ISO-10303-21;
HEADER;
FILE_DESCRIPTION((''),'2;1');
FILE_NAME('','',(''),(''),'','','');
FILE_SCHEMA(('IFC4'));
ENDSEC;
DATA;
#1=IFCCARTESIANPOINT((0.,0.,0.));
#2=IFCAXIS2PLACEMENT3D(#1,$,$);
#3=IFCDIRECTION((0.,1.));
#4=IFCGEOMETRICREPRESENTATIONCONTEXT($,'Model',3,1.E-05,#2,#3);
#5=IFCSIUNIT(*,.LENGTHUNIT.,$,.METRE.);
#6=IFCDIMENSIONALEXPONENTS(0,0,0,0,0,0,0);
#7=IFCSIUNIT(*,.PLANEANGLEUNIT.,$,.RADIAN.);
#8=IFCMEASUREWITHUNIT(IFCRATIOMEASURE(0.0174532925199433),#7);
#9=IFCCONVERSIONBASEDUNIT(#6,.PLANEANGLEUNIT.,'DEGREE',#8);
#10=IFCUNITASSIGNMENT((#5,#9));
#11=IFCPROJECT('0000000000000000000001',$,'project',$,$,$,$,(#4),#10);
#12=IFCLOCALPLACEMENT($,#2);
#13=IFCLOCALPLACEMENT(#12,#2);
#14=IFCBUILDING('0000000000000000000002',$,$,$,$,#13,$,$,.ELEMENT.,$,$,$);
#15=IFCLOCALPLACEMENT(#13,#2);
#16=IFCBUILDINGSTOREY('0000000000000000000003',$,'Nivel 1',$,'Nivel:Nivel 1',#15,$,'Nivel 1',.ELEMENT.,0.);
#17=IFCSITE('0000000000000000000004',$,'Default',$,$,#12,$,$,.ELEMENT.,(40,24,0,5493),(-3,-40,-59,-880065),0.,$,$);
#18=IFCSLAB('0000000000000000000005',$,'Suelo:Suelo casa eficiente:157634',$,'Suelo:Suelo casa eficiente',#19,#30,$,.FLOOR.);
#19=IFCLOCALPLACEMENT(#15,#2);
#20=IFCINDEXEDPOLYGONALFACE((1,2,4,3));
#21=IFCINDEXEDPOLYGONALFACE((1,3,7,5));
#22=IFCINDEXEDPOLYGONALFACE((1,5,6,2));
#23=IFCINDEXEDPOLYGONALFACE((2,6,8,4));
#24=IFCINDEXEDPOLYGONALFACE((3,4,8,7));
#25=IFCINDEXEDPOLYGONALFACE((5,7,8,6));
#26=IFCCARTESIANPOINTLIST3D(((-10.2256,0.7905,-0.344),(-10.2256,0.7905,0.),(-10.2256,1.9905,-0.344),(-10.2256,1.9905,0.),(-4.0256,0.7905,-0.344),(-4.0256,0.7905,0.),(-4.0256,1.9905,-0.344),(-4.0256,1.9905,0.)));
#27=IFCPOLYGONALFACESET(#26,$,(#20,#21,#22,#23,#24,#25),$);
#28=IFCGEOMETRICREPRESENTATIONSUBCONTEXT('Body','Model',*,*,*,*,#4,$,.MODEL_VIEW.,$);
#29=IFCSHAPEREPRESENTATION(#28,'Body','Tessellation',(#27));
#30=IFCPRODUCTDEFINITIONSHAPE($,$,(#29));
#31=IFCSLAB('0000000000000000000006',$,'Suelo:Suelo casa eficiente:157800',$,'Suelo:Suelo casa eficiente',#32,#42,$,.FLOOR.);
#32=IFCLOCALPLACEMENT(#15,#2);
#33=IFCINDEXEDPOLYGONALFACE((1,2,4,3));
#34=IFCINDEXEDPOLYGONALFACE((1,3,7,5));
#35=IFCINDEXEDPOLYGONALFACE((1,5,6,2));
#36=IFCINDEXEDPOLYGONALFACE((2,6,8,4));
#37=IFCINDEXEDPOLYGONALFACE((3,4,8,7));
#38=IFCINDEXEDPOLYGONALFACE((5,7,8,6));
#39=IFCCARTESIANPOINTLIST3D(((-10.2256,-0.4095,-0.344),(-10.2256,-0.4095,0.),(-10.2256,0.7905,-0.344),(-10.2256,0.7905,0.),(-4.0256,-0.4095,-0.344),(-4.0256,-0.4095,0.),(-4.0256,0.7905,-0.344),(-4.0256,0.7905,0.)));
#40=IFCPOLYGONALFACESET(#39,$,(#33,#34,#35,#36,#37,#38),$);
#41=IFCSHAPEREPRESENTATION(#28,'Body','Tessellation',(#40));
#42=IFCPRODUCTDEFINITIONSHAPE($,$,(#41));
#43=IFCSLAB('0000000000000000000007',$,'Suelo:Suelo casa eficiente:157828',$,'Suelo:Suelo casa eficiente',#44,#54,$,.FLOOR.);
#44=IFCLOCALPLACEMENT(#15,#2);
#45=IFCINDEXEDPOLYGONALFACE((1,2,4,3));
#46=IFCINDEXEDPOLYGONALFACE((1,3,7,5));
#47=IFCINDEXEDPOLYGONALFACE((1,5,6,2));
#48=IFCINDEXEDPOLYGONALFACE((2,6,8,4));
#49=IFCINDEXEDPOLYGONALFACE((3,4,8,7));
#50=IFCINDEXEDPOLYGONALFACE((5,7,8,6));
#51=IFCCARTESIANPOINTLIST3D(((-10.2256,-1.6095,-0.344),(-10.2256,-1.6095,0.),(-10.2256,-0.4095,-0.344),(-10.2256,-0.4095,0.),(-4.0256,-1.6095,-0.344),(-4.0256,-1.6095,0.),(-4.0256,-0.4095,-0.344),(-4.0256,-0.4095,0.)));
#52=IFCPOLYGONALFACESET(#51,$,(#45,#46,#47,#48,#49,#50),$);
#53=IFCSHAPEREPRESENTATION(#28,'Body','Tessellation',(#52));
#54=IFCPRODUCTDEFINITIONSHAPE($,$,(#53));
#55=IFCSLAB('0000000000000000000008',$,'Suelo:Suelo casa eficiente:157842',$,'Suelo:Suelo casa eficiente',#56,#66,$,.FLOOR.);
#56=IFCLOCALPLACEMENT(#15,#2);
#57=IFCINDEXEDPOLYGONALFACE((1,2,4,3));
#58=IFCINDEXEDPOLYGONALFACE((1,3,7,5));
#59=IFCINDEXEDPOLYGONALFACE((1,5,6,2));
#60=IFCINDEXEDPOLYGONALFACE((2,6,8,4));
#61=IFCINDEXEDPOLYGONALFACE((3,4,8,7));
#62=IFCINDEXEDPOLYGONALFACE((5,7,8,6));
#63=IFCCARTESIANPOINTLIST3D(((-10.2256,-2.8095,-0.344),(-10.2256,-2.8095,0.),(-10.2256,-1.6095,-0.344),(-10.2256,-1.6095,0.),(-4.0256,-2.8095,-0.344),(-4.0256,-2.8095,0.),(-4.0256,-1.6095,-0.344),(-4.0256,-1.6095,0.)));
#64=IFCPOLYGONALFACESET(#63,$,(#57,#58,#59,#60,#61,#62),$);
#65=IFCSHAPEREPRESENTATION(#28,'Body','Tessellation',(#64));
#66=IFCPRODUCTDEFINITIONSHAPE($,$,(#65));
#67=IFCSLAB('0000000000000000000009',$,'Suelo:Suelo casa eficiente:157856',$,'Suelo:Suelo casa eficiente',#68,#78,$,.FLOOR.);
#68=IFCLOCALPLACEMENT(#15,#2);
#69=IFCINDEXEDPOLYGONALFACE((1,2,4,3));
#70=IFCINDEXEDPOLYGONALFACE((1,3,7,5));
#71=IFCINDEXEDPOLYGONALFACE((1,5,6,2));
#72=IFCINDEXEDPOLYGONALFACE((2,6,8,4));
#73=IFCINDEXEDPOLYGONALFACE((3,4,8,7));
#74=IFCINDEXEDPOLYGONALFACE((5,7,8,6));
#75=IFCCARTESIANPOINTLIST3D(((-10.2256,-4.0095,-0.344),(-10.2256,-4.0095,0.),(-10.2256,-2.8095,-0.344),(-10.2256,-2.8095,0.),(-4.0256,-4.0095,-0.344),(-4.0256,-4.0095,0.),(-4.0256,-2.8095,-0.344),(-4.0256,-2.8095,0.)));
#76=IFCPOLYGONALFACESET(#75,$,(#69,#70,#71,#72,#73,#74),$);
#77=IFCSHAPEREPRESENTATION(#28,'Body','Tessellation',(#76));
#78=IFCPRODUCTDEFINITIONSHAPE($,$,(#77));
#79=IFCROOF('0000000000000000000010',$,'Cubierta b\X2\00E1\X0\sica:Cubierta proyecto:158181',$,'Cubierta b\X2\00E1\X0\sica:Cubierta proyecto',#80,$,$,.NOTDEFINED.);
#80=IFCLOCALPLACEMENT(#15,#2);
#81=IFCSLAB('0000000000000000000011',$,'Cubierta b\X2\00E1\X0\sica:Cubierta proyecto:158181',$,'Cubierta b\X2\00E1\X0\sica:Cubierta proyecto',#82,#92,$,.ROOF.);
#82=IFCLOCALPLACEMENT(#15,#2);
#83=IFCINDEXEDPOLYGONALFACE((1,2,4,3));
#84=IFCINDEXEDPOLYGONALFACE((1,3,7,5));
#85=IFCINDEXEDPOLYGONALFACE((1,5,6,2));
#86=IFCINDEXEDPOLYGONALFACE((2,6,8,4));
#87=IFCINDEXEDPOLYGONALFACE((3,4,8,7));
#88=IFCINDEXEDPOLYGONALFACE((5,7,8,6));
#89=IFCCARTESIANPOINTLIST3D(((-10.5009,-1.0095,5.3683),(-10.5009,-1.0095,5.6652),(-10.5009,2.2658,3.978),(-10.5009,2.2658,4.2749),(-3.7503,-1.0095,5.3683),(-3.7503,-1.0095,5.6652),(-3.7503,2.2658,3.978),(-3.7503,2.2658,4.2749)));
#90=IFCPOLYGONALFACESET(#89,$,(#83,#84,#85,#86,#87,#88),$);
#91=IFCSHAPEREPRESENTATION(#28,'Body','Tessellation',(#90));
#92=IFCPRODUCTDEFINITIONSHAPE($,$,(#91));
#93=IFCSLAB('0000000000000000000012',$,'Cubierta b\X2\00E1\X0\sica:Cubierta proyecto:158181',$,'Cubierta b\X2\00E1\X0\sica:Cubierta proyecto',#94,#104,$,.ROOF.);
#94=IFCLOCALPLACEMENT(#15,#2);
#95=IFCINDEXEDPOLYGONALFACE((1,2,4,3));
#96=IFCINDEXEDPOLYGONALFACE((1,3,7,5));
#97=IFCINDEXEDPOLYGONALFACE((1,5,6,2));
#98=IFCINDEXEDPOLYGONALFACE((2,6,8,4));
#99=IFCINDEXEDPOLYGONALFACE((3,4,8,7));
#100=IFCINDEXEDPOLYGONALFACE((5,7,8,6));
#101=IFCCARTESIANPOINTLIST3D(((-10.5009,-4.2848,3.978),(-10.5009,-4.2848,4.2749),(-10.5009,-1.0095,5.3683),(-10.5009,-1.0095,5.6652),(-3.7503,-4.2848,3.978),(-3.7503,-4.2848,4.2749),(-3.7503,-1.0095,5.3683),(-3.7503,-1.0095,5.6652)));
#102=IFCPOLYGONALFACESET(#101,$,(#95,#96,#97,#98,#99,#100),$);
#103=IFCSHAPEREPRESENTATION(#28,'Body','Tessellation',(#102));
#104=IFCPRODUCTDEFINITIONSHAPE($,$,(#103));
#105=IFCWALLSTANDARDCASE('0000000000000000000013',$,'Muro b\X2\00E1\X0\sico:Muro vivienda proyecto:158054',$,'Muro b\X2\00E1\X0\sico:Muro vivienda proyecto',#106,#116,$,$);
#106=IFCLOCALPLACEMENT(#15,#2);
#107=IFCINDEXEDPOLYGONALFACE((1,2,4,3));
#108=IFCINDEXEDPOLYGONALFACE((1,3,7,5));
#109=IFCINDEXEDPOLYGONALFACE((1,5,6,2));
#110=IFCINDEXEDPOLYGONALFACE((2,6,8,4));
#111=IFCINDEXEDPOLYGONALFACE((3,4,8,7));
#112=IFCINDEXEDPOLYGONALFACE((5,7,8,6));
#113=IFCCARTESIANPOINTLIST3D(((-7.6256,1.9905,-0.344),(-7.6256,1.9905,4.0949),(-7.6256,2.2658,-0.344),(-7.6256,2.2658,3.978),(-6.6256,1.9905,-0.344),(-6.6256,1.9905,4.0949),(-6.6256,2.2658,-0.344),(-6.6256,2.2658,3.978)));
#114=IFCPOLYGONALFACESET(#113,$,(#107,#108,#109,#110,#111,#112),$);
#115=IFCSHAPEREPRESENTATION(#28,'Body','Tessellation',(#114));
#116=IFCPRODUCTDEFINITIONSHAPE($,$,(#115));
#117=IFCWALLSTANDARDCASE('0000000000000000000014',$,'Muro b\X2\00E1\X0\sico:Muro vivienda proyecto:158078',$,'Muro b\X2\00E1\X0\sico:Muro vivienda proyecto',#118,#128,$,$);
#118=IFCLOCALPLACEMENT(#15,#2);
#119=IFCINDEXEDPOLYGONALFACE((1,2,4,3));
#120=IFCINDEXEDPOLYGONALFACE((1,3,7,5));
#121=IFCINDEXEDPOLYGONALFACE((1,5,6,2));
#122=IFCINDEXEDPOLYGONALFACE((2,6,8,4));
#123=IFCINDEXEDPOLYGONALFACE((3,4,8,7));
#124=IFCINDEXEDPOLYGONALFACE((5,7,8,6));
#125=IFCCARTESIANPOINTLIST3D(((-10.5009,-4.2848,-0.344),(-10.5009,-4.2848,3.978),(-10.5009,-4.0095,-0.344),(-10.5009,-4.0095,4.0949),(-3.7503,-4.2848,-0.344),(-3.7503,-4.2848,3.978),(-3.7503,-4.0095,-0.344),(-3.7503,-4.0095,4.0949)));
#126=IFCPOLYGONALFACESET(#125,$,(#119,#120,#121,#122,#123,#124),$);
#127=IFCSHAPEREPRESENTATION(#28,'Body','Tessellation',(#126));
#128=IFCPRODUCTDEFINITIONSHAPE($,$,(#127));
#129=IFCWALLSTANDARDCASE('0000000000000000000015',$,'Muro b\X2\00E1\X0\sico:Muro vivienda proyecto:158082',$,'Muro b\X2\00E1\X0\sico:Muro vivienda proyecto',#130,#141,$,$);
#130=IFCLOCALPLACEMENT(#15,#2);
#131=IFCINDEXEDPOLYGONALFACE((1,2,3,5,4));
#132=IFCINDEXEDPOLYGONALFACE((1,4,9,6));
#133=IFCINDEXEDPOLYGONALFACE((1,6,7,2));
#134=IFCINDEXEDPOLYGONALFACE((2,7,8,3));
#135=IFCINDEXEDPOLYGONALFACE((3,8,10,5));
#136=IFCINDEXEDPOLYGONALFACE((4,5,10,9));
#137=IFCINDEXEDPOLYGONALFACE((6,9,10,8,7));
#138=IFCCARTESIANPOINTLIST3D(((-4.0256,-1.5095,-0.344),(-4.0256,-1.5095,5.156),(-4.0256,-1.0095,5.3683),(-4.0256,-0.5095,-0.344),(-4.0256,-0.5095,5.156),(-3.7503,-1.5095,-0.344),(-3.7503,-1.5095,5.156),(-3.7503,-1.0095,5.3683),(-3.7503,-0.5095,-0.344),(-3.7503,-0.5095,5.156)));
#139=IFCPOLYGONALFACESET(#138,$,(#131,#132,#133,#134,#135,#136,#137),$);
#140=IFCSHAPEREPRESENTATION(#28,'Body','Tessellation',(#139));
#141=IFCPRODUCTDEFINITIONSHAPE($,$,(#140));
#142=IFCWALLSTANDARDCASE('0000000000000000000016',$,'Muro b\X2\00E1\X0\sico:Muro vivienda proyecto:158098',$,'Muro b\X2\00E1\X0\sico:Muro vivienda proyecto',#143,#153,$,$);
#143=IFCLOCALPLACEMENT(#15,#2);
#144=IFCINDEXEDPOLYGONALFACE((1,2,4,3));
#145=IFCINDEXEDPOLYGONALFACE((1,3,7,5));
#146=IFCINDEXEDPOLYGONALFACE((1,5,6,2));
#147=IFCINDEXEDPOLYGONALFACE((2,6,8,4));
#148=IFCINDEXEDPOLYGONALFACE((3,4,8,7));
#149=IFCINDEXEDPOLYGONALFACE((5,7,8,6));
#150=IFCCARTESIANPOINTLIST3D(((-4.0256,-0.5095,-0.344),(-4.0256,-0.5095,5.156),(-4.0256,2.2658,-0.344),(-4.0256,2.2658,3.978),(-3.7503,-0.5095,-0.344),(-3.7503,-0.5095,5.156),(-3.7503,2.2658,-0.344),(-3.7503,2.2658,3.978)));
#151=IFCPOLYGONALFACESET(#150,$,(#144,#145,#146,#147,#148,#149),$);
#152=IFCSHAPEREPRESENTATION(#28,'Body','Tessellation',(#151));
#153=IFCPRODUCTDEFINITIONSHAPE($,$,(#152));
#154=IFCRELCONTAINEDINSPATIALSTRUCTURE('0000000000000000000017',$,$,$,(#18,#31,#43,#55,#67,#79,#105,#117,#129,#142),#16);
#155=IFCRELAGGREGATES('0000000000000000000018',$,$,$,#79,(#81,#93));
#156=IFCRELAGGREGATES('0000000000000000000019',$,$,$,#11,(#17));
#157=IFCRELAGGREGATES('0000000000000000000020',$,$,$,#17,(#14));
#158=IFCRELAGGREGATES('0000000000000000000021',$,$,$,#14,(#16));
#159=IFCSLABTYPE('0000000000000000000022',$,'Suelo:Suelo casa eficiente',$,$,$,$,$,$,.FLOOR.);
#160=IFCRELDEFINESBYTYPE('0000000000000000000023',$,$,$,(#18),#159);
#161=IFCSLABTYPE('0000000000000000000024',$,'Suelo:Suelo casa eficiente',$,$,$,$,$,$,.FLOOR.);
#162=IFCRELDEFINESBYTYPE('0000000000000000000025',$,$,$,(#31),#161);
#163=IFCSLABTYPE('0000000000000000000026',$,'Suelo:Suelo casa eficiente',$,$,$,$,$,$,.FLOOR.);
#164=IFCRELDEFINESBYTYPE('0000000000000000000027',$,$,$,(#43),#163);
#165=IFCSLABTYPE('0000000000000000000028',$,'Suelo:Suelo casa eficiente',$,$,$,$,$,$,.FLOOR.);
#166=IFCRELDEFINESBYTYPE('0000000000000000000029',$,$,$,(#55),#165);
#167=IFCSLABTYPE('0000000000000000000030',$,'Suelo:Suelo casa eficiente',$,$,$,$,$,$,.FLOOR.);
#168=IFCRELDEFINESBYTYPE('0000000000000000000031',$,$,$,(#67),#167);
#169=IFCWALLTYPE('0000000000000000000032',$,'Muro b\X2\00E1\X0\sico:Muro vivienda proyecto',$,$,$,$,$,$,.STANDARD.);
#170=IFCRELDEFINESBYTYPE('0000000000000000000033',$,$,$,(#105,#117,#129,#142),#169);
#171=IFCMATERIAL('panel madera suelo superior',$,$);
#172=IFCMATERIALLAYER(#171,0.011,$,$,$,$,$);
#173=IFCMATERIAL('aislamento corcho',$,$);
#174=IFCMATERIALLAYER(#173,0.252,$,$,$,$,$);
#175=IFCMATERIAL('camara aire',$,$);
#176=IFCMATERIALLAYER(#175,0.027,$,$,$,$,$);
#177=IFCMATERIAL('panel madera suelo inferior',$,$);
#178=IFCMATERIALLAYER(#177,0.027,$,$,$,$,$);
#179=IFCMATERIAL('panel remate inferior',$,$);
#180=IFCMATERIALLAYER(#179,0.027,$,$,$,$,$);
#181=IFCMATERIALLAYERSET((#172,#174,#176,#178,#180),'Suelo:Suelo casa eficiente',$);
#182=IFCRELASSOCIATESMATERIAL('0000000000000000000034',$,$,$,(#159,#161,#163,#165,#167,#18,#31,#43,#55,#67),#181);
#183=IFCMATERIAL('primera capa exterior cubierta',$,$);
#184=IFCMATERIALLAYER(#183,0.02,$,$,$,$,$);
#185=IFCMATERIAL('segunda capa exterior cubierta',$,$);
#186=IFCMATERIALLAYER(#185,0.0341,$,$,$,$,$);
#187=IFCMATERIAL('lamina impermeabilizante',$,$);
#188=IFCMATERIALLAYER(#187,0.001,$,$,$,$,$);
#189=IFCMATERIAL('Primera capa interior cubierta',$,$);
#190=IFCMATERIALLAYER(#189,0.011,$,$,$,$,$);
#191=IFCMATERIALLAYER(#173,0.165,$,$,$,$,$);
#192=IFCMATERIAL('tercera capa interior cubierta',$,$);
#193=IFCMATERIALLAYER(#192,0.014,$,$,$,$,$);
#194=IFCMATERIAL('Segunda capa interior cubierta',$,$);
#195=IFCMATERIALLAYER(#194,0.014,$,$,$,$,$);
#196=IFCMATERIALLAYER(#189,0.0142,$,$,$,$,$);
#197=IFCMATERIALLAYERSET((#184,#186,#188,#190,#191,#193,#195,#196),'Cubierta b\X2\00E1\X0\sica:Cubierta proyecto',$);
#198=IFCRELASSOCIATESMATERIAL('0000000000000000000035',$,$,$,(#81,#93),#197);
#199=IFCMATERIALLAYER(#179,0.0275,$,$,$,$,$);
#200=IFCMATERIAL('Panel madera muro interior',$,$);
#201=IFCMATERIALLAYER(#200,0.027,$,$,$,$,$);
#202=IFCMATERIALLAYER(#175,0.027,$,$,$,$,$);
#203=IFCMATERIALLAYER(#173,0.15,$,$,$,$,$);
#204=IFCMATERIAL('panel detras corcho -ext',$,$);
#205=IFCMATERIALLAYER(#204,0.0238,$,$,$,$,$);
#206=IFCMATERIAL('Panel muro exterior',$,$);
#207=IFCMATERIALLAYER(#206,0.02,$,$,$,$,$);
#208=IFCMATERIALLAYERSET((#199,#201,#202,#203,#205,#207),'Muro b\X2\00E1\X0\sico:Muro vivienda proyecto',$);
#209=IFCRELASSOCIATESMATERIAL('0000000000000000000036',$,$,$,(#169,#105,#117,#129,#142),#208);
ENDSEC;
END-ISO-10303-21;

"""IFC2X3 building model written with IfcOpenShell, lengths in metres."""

from ifc_helpers import new_model, entity, si_unit, converted_unit, direction, frame, frame_2d, origin, place, context, subcontext, project, spatial, polyline, rectangle, extrude, clip, bounded_halfspace, material, layer, layer_set, layer_usage, type_object, element, aggregate, save


model = new_model("IFC2X3")

# Units and contexts
model_context = context("Model", 3, precision=1e-05, world=origin(), true_north=direction((0.0, 1.0)))
body_context = subcontext(model_context, "Body", "Model", "MODEL_VIEW")
ifc_project = project(units=[si_unit("LENGTHUNIT", "METRE"), converted_unit("PLANEANGLEUNIT", "DEGREE", entity("IfcRatioMeasure", 0.0174532925199433), si_unit("PLANEANGLEUNIT", "RADIAN"), dimensions=[0, 0, 0, 0, 0, 0, 0])], contexts=[model_context])

# Site, building, storey
site_placement = place(None, origin())
site = spatial("IfcSite", under=ifc_project, at=site_placement, Name="Default", CompositionType="ELEMENT", RefLatitude=(40, 24, 0, 5493), RefLongitude=(-3, -40, -59, -880065), RefElevation=0.0)
building_placement = place(site_placement, origin())
building = spatial("IfcBuilding", under=site, at=building_placement, CompositionType="ELEMENT")
storey_placement = place(building_placement, origin())
storey = spatial("IfcBuildingStorey", under=building, at=storey_placement, Name="Nivel 1", ObjectType="Nivel:Nivel 1", LongName="Nivel 1", CompositionType="ELEMENT", Elevation=0.0)

# Slabs
ifc_material_1 = material(Name="panel madera suelo superior")
ifc_layer_1 = layer(ifc_material_1, 0.011)
ifc_material_2 = material(Name="aislamento corcho")
ifc_layer_2 = layer(ifc_material_2, 0.252)
ifc_material_3 = material(Name="camara aire")
ifc_layer_3 = layer(ifc_material_3, 0.027)
ifc_material_4 = material(Name="panel madera suelo inferior")
ifc_layer_4 = layer(ifc_material_4, 0.027)
ifc_material_5 = material(Name="panel remate inferior")
ifc_layer_5 = layer(ifc_material_5, 0.027)
ifc_layer_set_1 = layer_set([ifc_layer_1, ifc_layer_2, ifc_layer_3, ifc_layer_4, ifc_layer_5], Name="Suelo:Suelo casa eficiente")
ifc_layer_usage_1 = layer_usage(ifc_layer_set_1, "AXIS3", "POSITIVE", 0.0)
slab_type_1 = type_object("IfcSlabType", Name="Suelo:Suelo casa eficiente", PredefinedType="FLOOR", material=ifc_layer_set_1)
slab_1_placement = place(storey_placement, origin())
element("IfcSlab", 1, at=slab_1_placement, inside=storey, type_object=slab_type_1, material=ifc_layer_usage_1, Name="Suelo:Suelo casa eficiente:157634", ObjectType="Suelo:Suelo casa eficiente", PredefinedType="FLOOR", context=body_context, shape_type="SweptSolid", body=[
    extrude(rectangle(XDim=1.2, YDim=6.2, at=frame_2d((0.0, 0.0), x_axis=(1.0, 0.0))), frame((-7.1256, 1.3905, 0.0), z_axis=(0.0, 0.0, -1.0), x_axis=(0.0, 1.0, 0.0)), (0.0, 0.0, 1.0), 0.344),
])
ifc_layer_usage_2 = layer_usage(ifc_layer_set_1, "AXIS3", "POSITIVE", 0.0)
slab_type_2 = type_object("IfcSlabType", Name="Suelo:Suelo casa eficiente", PredefinedType="FLOOR", material=ifc_layer_set_1)
slab_2_placement = place(storey_placement, origin())
element("IfcSlab", 2, at=slab_2_placement, inside=storey, type_object=slab_type_2, material=ifc_layer_usage_2, Name="Suelo:Suelo casa eficiente:157800", ObjectType="Suelo:Suelo casa eficiente", PredefinedType="FLOOR", context=body_context, shape_type="SweptSolid", body=[
    extrude(rectangle(XDim=1.2, YDim=6.2, at=frame_2d((0.0, 0.0), x_axis=(1.0, 0.0))), frame((-7.1256, 0.1905, 0.0), z_axis=(0.0, 0.0, -1.0), x_axis=(0.0, 1.0, 0.0)), (0.0, 0.0, 1.0), 0.344),
])
ifc_layer_usage_3 = layer_usage(ifc_layer_set_1, "AXIS3", "POSITIVE", 0.0)
slab_type_3 = type_object("IfcSlabType", Name="Suelo:Suelo casa eficiente", PredefinedType="FLOOR", material=ifc_layer_set_1)
slab_3_placement = place(storey_placement, origin())
element("IfcSlab", 3, at=slab_3_placement, inside=storey, type_object=slab_type_3, material=ifc_layer_usage_3, Name="Suelo:Suelo casa eficiente:157828", ObjectType="Suelo:Suelo casa eficiente", PredefinedType="FLOOR", context=body_context, shape_type="SweptSolid", body=[
    extrude(rectangle(XDim=1.2, YDim=6.2, at=frame_2d((0.0, 0.0), x_axis=(1.0, 0.0))), frame((-7.1256, -1.0095, 0.0), z_axis=(0.0, 0.0, -1.0), x_axis=(0.0, 1.0, 0.0)), (0.0, 0.0, 1.0), 0.344),
])
ifc_layer_usage_4 = layer_usage(ifc_layer_set_1, "AXIS3", "POSITIVE", 0.0)
slab_type_4 = type_object("IfcSlabType", Name="Suelo:Suelo casa eficiente", PredefinedType="FLOOR", material=ifc_layer_set_1)
slab_4_placement = place(storey_placement, origin())
element("IfcSlab", 4, at=slab_4_placement, inside=storey, type_object=slab_type_4, material=ifc_layer_usage_4, Name="Suelo:Suelo casa eficiente:157842", ObjectType="Suelo:Suelo casa eficiente", PredefinedType="FLOOR", context=body_context, shape_type="SweptSolid", body=[
    extrude(rectangle(XDim=1.2, YDim=6.2, at=frame_2d((0.0, 0.0), x_axis=(1.0, 0.0))), frame((-7.1256, -2.2095, 0.0), z_axis=(0.0, 0.0, -1.0), x_axis=(0.0, 1.0, 0.0)), (0.0, 0.0, 1.0), 0.344),
])
ifc_layer_usage_5 = layer_usage(ifc_layer_set_1, "AXIS3", "POSITIVE", 0.0)
slab_type_5 = type_object("IfcSlabType", Name="Suelo:Suelo casa eficiente", PredefinedType="FLOOR", material=ifc_layer_set_1)
slab_5_placement = place(storey_placement, origin())
element("IfcSlab", 5, at=slab_5_placement, inside=storey, type_object=slab_type_5, material=ifc_layer_usage_5, Name="Suelo:Suelo casa eficiente:157856", ObjectType="Suelo:Suelo casa eficiente", PredefinedType="FLOOR", context=body_context, shape_type="SweptSolid", body=[
    extrude(rectangle(XDim=1.2, YDim=6.2, at=frame_2d((0.0, 0.0), x_axis=(1.0, 0.0))), frame((-7.1256, -3.4095, 0.0), z_axis=(0.0, 0.0, -1.0), x_axis=(0.0, 1.0, 0.0)), (0.0, 0.0, 1.0), 0.344),
])

# Roof, slabs
roof_placement = place(storey_placement, frame((-10.5009, -4.2848, 3.978)))
roof = element("IfcRoof", 6, at=roof_placement, inside=storey, Name="Cubierta básica:Cubierta proyecto:158181", ObjectType="Cubierta básica:Cubierta proyecto", ShapeType="NOTDEFINED")
ifc_material_6 = material(Name="primera capa exterior cubierta")
ifc_layer_6 = layer(ifc_material_6, 0.02)
ifc_material_7 = material(Name="segunda capa exterior cubierta")
ifc_layer_7 = layer(ifc_material_7, 0.0341)
ifc_material_8 = material(Name="lamina impermeabilizante")
ifc_layer_8 = layer(ifc_material_8, 0.001)
ifc_material_9 = material(Name="Primera capa interior cubierta")
ifc_layer_9 = layer(ifc_material_9, 0.011)
ifc_layer_10 = layer(ifc_material_2, 0.165)
ifc_material_10 = material(Name="tercera capa interior cubierta")
ifc_layer_11 = layer(ifc_material_10, 0.014)
ifc_material_11 = material(Name="Segunda capa interior cubierta")
ifc_layer_12 = layer(ifc_material_11, 0.014)
ifc_layer_13 = layer(ifc_material_9, 0.0142)
ifc_layer_set_2 = layer_set([ifc_layer_6, ifc_layer_7, ifc_layer_8, ifc_layer_9, ifc_layer_10, ifc_layer_11, ifc_layer_12, ifc_layer_13], Name="Cubierta básica:Cubierta proyecto")
slab_6_placement = place(roof_placement, origin())
slab_6 = element("IfcSlab", 7, at=slab_6_placement, material=ifc_layer_set_2, Name="Cubierta básica:Cubierta proyecto:158181", ObjectType="Cubierta básica:Cubierta proyecto", PredefinedType="ROOF", context=body_context, shape_type="SweptSolid", body=[
    extrude(rectangle(XDim=6.7506, YDim=3.5582, at=frame_2d((0.0, 0.0), x_axis=(1.0, 0.0))), frame((3.3753, 4.913, 0.6951), z_axis=(0.0, 0.390731, 0.920505), x_axis=(1.0, 0.0, 0.0)), (0.0, -0.390731, 0.920505), 0.2969),
])
slab_7_placement = place(roof_placement, origin())
slab_7 = element("IfcSlab", 8, at=slab_7_placement, material=ifc_layer_set_2, Name="Cubierta básica:Cubierta proyecto:158181", ObjectType="Cubierta básica:Cubierta proyecto", PredefinedType="ROOF", context=body_context, shape_type="SweptSolid", body=[
    extrude(rectangle(XDim=3.5582, YDim=6.7506, at=frame_2d((0.0, 0.0), x_axis=(0.0, 1.0))), frame((3.3753, 1.6377, 0.6951), z_axis=(0.0, -0.390731, 0.920505), x_axis=(1.0, 0.0, 0.0)), (0.0, 0.390731, 0.920505), 0.2969),
])
aggregate(roof, [slab_6, slab_7])

# Walls
ifc_layer_14 = layer(ifc_material_5, 0.0275)
ifc_material_12 = material(Name="Panel madera muro interior")
ifc_layer_15 = layer(ifc_material_12, 0.027)
ifc_layer_16 = layer(ifc_material_3, 0.027)
ifc_layer_17 = layer(ifc_material_2, 0.15)
ifc_material_13 = material(Name="panel detras corcho -ext")
ifc_layer_18 = layer(ifc_material_13, 0.0238)
ifc_material_14 = material(Name="Panel muro exterior")
ifc_layer_19 = layer(ifc_material_14, 0.02)
ifc_layer_set_3 = layer_set([ifc_layer_14, ifc_layer_15, ifc_layer_16, ifc_layer_17, ifc_layer_18, ifc_layer_19], Name="Muro básico:Muro vivienda proyecto")
ifc_layer_usage_6 = layer_usage(ifc_layer_set_3, "AXIS2", "NEGATIVE", 0.1376)
wall_type = type_object("IfcWallType", Name="Muro básico:Muro vivienda proyecto", PredefinedType="STANDARD", material=ifc_layer_set_3)
wall_1_placement = place(storey_placement, frame((-7.6256, 2.1282, -0.344)))
element("IfcWallStandardCase", 9, at=wall_1_placement, inside=storey, type_object=wall_type, material=ifc_layer_usage_6, Name="Muro básico:Muro vivienda proyecto:158054", ObjectType="Muro básico:Muro vivienda proyecto", context=body_context, shape_type="Clipping", body=[
    clip(extrude(rectangle(XDim=1.0, YDim=0.2753, at=frame_2d((0.5, 0.0), x_axis=(-1.0, 0.0))), origin(), (0.0, 0.0, 1.0), 4.4389), bounded_halfspace(frame((0.0, -0.1376, 4.4389), z_axis=(0.0, 0.390731, 0.920505), x_axis=(-1.0, 0.0, 0.0)), False, frame((0.0, -0.1376, 4.4389)), polyline([(0.0, 0.0), (1.0, 0.0), (1.0, 0.2753), (0.0, 0.2753), (0.0, 0.0)]))),
])
ifc_layer_usage_7 = layer_usage(ifc_layer_set_3, "AXIS2", "NEGATIVE", 0.1376)
wall_2_placement = place(storey_placement, frame((-3.7503, -4.1471, -0.344), z_axis=(0.0, 0.0, 1.0), x_axis=(-1.0, 0.0, 0.0)))
element("IfcWallStandardCase", 10, at=wall_2_placement, inside=storey, type_object=wall_type, material=ifc_layer_usage_7, Name="Muro básico:Muro vivienda proyecto:158078", ObjectType="Muro básico:Muro vivienda proyecto", context=body_context, shape_type="Clipping", body=[
    clip(extrude(rectangle(XDim=6.7506, YDim=0.2753, at=frame_2d((3.3753, 0.0), x_axis=(-1.0, 0.0))), origin(), (0.0, 0.0, 1.0), 4.4389), bounded_halfspace(frame((0.0, -0.1376, 4.4389), z_axis=(0.0, 0.390731, 0.920505), x_axis=(-1.0, 0.0, 0.0)), False, frame((0.0, -0.1376, 4.4389)), polyline([(0.0, 0.0), (0.2753, 0.0), (6.4753, 0.0), (6.7506, 0.0), (6.7506, 0.2753), (0.0, 0.2753), (0.0, 0.0)]))),
])
ifc_layer_usage_8 = layer_usage(ifc_layer_set_3, "AXIS2", "NEGATIVE", 0.1376)
wall_3_placement = place(storey_placement, frame((-3.8879, -0.5095, -0.344), z_axis=(0.0, 0.0, 1.0), x_axis=(0.0, -1.0, 0.0)))
element("IfcWallStandardCase", 11, at=wall_3_placement, inside=storey, type_object=wall_type, material=ifc_layer_usage_8, Name="Muro básico:Muro vivienda proyecto:158082", ObjectType="Muro básico:Muro vivienda proyecto", context=body_context, shape_type="Clipping", body=[
    clip(clip(extrude(rectangle(XDim=1.0, YDim=0.2753, at=frame_2d((0.5, 0.0), x_axis=(-1.0, 0.0))), origin(), (0.0, 0.0, 1.0), 5.7123), bounded_halfspace(frame((0.5, -0.1376, 5.7123), z_axis=(0.390731, 0.0, 0.920505), x_axis=(0.0, 1.0, 0.0)), False, frame((0.5, -0.1376, 5.7123)), polyline([(0.0, 0.0), (0.5, 0.0), (0.5, 0.2753), (0.0, 0.2753), (0.0, 0.0)]))), bounded_halfspace(frame((0.0, -0.1376, 5.5), z_axis=(-0.390731, 0.0, 0.920505), x_axis=(0.0, -1.0, 0.0)), False, frame((0.0, -0.1376, 5.5)), polyline([(0.0, 0.0), (0.5, 0.0), (0.5, 0.2753), (0.0, 0.2753), (0.0, 0.0)]))),
])
ifc_layer_usage_9 = layer_usage(ifc_layer_set_3, "AXIS2", "NEGATIVE", 0.1376)
wall_4_placement = place(storey_placement, frame((-3.8879, 2.2658, -0.344), z_axis=(0.0, 0.0, 1.0), x_axis=(0.0, -1.0, 0.0)))
element("IfcWallStandardCase", 12, at=wall_4_placement, inside=storey, type_object=wall_type, material=ifc_layer_usage_9, Name="Muro básico:Muro vivienda proyecto:158098", ObjectType="Muro básico:Muro vivienda proyecto", context=body_context, shape_type="Clipping", body=[
    clip(extrude(rectangle(XDim=2.7753, YDim=0.2753, at=frame_2d((1.3877, 0.0), x_axis=(-1.0, 0.0))), origin(), (0.0, 0.0, 1.0), 5.5), bounded_halfspace(frame((0.0, -0.1376, 4.322), z_axis=(-0.390731, 0.0, 0.920505), x_axis=(0.0, -1.0, 0.0)), False, frame((0.0, -0.1376, 4.322)), polyline([(0.0, 0.0), (0.2753, 0.0), (2.7753, 0.0), (2.7753, 0.2753), (0.0, 0.2753), (0.0, 0.0)]))),
])

save(model, "model.ifc")
